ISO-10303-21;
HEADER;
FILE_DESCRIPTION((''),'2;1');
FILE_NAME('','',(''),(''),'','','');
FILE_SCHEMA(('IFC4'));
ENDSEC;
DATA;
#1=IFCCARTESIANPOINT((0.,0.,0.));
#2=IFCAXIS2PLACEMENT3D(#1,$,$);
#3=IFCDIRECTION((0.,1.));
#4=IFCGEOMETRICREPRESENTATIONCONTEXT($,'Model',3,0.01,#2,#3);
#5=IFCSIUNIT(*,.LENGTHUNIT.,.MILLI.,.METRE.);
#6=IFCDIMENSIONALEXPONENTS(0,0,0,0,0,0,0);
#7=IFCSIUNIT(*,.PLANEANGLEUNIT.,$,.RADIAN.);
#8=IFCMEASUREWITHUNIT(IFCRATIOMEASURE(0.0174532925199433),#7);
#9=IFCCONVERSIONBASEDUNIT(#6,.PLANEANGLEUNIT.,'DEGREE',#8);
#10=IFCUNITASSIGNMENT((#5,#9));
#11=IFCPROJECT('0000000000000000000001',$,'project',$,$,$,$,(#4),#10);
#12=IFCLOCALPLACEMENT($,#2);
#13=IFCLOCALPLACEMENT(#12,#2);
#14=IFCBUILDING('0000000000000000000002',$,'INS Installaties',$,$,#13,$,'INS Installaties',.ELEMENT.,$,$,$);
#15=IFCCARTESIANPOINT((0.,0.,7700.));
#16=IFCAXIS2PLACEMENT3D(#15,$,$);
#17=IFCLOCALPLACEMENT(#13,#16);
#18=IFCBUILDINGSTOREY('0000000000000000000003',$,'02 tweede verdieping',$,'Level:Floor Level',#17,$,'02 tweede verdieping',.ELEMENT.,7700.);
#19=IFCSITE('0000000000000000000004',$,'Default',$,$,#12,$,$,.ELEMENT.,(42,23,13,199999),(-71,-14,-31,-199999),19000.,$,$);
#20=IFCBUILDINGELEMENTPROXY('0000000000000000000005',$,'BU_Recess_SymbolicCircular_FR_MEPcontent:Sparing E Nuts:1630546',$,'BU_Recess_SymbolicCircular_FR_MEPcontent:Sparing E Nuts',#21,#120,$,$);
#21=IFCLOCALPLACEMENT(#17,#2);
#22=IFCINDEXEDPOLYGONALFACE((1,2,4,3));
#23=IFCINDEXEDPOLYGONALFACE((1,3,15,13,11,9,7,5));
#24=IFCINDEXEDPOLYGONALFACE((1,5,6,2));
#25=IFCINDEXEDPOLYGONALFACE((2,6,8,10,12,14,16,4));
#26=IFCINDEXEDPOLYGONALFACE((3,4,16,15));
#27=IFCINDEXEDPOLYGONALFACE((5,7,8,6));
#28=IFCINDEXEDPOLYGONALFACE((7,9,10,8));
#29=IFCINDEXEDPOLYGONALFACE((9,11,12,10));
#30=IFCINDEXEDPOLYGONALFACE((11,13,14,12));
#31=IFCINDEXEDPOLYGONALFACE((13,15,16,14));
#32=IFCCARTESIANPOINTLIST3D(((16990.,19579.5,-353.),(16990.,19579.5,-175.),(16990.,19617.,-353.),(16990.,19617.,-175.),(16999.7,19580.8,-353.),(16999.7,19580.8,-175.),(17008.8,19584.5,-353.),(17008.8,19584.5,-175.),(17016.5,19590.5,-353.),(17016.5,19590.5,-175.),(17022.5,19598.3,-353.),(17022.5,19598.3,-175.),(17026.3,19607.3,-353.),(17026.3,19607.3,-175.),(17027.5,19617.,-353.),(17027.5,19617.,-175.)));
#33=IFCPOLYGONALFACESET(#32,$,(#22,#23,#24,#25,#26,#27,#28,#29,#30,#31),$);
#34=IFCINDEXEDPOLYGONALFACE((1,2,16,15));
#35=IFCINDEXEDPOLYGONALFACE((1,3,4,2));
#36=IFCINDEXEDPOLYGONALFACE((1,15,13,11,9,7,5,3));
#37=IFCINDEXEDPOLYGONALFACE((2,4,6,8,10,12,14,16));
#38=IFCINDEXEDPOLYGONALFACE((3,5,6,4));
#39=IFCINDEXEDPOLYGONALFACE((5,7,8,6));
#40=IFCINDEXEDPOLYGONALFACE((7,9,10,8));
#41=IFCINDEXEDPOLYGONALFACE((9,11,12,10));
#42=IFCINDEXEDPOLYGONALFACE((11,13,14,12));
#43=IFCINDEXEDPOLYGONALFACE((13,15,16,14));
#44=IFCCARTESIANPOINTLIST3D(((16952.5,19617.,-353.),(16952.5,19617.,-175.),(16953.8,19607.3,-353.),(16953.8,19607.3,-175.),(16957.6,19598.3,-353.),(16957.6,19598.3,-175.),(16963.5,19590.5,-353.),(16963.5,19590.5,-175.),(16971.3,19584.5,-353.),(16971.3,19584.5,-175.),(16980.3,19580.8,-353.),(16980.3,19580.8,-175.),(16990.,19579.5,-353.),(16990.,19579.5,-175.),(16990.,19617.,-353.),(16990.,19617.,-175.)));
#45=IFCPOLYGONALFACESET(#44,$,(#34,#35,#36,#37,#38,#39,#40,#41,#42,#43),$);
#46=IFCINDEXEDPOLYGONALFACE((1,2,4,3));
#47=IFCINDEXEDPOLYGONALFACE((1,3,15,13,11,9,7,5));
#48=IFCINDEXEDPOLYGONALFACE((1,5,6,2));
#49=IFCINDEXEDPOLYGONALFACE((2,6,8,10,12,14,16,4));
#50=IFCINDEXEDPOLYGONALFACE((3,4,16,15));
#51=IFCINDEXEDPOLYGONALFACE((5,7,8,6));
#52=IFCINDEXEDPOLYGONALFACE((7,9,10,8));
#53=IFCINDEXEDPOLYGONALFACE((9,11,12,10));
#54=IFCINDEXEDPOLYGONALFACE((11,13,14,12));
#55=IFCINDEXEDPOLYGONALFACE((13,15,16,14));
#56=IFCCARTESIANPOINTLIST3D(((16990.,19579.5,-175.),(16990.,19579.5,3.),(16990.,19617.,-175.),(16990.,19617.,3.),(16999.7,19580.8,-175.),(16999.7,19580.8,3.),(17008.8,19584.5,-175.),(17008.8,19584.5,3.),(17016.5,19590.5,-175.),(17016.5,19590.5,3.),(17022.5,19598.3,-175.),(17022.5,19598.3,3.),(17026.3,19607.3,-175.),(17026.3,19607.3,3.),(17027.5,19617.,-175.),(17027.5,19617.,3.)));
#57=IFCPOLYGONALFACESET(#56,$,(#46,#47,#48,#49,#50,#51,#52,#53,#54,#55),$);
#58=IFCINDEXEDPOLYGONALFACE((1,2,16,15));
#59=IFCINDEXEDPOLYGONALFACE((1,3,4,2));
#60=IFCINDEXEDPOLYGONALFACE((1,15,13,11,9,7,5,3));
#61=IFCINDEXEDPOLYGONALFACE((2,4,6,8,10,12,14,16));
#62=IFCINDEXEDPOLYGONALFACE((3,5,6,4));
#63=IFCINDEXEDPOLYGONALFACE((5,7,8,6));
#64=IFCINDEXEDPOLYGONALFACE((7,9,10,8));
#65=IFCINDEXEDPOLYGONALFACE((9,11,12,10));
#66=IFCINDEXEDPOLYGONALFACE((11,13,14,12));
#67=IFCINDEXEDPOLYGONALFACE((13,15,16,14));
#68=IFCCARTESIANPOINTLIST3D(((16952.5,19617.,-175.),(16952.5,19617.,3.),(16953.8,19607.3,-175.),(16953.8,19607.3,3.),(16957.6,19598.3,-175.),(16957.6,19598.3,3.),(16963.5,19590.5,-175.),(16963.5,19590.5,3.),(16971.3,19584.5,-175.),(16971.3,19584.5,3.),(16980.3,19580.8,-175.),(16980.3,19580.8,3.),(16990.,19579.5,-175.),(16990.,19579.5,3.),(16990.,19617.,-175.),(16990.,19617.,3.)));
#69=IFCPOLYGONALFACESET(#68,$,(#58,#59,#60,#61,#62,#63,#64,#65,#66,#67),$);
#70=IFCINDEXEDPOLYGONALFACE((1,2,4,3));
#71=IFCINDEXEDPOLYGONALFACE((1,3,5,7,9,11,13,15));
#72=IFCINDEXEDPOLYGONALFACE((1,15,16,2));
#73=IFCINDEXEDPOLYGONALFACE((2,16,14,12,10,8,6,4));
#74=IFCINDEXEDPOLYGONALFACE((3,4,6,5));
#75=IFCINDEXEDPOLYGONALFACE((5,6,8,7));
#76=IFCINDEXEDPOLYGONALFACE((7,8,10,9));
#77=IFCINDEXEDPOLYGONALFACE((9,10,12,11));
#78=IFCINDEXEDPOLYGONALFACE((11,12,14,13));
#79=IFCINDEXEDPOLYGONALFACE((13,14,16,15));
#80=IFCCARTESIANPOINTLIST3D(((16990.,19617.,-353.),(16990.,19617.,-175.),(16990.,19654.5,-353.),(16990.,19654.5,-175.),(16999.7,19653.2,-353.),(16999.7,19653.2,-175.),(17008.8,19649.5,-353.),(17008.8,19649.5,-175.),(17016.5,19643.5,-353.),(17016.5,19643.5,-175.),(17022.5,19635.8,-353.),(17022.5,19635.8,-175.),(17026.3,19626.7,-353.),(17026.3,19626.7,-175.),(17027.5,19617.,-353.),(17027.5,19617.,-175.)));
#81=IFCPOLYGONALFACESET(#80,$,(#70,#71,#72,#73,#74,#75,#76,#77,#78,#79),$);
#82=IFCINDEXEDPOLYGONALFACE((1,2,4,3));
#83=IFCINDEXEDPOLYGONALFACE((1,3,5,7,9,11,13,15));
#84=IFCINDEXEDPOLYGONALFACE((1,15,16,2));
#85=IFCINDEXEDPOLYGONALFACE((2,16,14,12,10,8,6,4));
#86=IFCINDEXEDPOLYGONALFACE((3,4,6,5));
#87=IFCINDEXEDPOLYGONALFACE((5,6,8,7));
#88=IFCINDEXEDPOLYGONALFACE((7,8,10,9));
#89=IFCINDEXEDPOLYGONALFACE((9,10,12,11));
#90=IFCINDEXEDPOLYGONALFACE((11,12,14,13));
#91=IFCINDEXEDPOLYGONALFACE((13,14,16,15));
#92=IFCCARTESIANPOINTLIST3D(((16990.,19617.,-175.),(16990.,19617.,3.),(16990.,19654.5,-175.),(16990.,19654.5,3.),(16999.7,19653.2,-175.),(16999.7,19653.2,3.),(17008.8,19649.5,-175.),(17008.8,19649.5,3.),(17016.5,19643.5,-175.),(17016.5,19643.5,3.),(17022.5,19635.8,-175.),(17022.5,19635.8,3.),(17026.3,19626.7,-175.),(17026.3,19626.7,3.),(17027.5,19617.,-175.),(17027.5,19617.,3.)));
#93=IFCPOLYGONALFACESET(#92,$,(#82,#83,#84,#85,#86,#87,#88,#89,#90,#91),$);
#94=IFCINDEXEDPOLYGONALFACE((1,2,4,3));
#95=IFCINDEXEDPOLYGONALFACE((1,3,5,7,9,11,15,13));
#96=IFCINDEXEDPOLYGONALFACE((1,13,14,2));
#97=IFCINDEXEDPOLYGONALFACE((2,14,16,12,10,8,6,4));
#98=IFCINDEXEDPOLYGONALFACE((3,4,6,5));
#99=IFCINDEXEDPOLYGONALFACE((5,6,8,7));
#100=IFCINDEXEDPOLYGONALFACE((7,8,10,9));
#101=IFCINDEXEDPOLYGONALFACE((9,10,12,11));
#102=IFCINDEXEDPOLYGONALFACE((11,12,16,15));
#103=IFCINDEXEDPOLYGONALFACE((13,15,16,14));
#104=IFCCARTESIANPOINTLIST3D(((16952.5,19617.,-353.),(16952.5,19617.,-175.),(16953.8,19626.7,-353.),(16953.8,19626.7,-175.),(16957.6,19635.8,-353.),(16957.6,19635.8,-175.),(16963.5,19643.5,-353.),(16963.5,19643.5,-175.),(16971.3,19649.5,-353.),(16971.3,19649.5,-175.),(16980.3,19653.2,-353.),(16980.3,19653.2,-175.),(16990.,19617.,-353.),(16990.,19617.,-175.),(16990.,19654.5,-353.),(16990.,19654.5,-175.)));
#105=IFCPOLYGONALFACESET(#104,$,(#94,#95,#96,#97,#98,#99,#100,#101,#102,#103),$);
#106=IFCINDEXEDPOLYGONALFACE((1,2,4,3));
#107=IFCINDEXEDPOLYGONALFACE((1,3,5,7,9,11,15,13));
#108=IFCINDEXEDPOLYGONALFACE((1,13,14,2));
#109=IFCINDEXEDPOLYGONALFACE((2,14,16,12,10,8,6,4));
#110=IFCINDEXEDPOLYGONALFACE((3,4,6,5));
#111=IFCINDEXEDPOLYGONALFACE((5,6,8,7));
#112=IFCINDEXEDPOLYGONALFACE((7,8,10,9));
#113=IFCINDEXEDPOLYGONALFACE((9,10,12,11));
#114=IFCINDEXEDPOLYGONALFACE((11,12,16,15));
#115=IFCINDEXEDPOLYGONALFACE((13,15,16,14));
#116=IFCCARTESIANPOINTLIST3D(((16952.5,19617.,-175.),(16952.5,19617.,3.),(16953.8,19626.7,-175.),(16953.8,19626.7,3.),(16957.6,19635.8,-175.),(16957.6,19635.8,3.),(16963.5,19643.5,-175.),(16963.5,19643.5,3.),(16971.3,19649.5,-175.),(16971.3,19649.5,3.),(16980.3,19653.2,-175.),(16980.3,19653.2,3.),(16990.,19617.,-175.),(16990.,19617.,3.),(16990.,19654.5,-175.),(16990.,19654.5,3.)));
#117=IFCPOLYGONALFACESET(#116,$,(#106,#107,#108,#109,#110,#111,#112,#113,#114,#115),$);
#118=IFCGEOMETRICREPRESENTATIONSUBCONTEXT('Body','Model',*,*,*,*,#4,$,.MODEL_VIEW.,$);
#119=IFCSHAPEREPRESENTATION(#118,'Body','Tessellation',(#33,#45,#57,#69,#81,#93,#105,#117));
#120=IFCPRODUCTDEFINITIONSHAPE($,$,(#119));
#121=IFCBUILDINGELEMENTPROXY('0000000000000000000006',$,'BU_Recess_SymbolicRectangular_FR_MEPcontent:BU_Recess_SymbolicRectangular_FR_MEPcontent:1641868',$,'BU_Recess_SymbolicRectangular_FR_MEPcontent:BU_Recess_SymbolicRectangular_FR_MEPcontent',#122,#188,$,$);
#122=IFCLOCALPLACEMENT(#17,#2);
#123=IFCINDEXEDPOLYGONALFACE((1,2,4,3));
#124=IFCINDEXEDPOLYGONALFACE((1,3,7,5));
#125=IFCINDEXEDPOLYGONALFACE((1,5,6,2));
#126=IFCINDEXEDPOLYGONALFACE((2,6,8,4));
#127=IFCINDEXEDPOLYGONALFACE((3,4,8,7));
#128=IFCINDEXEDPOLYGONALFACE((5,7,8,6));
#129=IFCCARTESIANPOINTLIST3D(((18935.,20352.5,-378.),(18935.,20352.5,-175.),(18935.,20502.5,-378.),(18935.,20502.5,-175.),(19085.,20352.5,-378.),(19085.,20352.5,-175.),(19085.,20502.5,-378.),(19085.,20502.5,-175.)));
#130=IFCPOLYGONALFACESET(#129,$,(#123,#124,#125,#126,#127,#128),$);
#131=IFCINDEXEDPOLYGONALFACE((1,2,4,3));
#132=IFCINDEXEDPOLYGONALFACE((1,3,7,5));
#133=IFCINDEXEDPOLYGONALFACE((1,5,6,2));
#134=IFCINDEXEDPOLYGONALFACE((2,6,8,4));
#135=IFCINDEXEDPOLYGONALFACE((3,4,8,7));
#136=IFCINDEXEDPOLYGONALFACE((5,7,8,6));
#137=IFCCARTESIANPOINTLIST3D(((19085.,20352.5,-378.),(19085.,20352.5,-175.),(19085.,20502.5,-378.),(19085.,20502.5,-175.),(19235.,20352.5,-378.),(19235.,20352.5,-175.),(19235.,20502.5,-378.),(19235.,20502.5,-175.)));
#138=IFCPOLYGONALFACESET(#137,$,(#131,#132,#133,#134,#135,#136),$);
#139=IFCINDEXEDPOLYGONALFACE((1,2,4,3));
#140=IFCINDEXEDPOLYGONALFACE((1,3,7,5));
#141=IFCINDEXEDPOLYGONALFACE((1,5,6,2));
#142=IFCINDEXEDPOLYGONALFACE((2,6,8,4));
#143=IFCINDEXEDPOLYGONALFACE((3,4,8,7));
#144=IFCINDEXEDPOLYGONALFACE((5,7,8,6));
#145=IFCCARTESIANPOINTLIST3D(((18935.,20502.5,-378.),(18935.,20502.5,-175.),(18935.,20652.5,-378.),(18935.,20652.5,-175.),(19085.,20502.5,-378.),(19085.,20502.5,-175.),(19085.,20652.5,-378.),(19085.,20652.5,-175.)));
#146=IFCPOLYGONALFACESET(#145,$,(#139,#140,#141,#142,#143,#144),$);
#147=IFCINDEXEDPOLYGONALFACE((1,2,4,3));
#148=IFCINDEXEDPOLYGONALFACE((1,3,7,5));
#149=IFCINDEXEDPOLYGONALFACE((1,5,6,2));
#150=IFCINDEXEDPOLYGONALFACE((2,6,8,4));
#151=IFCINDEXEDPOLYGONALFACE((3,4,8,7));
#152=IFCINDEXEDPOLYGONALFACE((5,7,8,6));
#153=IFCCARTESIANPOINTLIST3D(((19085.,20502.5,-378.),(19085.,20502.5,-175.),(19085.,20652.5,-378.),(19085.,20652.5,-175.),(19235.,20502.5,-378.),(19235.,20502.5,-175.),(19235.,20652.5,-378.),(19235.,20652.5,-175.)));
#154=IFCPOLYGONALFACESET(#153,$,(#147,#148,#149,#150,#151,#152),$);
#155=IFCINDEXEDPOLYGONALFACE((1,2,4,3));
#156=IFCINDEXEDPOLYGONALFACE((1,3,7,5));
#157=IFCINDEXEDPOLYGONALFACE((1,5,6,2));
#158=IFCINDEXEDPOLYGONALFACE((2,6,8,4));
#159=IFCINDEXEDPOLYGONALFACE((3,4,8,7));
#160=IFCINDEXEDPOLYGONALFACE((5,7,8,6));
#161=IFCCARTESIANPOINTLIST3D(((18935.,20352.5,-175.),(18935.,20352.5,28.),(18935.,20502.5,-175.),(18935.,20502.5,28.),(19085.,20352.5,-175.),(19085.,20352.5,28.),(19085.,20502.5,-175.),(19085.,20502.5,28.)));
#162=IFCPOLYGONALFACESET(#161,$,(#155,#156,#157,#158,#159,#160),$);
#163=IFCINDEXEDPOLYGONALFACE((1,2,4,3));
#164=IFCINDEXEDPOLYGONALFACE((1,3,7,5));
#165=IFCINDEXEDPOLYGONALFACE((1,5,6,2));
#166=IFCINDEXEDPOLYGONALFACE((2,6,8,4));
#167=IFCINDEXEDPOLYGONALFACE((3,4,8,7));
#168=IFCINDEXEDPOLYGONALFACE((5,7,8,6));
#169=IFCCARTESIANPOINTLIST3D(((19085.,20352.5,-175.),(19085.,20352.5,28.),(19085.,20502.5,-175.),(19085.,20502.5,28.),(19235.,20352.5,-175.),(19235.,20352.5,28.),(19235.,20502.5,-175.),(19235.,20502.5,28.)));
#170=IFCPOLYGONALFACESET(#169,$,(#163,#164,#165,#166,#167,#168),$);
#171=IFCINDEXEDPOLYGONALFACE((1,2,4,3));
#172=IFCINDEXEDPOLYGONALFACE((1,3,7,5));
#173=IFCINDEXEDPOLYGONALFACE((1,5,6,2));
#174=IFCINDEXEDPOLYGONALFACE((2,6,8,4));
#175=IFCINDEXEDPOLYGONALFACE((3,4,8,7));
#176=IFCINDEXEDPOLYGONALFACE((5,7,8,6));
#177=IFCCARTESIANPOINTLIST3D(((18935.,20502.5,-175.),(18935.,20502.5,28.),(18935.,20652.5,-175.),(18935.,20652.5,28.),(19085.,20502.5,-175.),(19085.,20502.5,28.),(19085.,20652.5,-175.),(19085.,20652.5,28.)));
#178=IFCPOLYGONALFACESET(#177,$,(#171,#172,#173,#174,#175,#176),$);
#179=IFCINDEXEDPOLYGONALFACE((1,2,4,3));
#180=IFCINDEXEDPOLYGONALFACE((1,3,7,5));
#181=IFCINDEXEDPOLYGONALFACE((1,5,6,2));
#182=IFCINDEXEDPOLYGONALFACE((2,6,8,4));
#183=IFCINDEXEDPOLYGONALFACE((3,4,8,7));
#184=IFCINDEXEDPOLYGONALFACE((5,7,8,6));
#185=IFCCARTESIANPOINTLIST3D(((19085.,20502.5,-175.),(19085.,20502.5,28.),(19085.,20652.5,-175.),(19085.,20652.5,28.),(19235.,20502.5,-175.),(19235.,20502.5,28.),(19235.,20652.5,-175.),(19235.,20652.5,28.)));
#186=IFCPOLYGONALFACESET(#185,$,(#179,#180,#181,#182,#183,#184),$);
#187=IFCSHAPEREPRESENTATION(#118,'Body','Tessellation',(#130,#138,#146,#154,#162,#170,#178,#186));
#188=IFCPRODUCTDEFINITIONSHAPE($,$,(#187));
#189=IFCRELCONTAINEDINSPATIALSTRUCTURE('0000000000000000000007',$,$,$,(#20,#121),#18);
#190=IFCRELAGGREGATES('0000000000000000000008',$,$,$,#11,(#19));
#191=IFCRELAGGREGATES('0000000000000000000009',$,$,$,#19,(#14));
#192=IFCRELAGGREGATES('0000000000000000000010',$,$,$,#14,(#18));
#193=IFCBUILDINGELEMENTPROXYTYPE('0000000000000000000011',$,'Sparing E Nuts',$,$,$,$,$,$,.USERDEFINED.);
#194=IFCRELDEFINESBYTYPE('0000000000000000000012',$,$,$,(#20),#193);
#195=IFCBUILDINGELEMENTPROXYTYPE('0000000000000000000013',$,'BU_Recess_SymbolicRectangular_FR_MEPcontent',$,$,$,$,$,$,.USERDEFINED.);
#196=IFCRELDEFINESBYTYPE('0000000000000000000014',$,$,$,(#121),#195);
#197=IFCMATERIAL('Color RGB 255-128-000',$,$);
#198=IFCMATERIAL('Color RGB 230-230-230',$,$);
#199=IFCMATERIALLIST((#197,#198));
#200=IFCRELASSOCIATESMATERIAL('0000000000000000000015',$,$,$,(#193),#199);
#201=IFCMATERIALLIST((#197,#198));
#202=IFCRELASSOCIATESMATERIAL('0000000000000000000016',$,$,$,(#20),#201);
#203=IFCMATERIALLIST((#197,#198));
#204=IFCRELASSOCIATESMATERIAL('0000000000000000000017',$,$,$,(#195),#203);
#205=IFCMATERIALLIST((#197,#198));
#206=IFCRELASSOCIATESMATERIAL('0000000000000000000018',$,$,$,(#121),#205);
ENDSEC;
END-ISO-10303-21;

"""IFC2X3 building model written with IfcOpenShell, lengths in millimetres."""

from ifc_helpers import new_model, entity, si_unit, converted_unit, direction, frame, frame_2d, origin, origin_2d_with_axis, place, context, subcontext, project, spatial, polyline, circle_curve, parameter, trimmed, segment, composite_curve, rectangle, outline, extrude, source, transform, mapped, material, material_list, type_object, type_shapes, element, save


model = new_model("IFC2X3")

# Units and contexts
model_context = context("Model", 3, precision=0.01, world=origin(), true_north=direction((0.0, 1.0)))
body_context = subcontext(model_context, "Body", "Model", "MODEL_VIEW")
ifc_project = project(units=[si_unit("LENGTHUNIT", "METRE", prefix="MILLI"), converted_unit("PLANEANGLEUNIT", "DEGREE", entity("IfcRatioMeasure", 0.0174532925199433), si_unit("PLANEANGLEUNIT", "RADIAN"), dimensions=[0, 0, 0, 0, 0, 0, 0])], contexts=[model_context])

# Site, building, storey
site_placement = place(None, origin())
site = spatial("IfcSite", under=ifc_project, at=site_placement, Name="Default", CompositionType="ELEMENT", RefLatitude=(42, 23, 13, 199999), RefLongitude=(-71, -14, -31, -199999), RefElevation=19000.0)
building_placement = place(site_placement, origin())
building = spatial("IfcBuilding", under=site, at=building_placement, Name="INS Installaties", LongName="INS Installaties", CompositionType="ELEMENT")
storey_placement = place(building_placement, frame((0.0, 0.0, 7700.0)))
storey = spatial("IfcBuildingStorey", under=building, at=storey_placement, Name="02 tweede verdieping", ObjectType="Level:Floor Level", LongName="02 tweede verdieping", CompositionType="ELEMENT", Elevation=7700.0)

# Building element proxies
ifc_material_1 = material(Name="Color RGB 255-128-000")
ifc_material_2 = material(Name="Color RGB 230-230-230")
ifc_material_list_1 = material_list([ifc_material_1, ifc_material_2])
building_element_proxy_type_1 = type_object("IfcBuildingElementProxyType", Name="Sparing E Nuts", PredefinedType="USERDEFINED", material=ifc_material_list_1)
shared_shape_1 = source(origin(), body_context, "Body", "SweptSolid", [
    extrude(outline(composite_curve([segment(polyline([(-25.0, -12.5), (12.5, -12.5)]), True, "CONTINUOUS"), segment(polyline([(12.5, -12.5), (12.5, 25.0)]), True, "CONTINUOUS"), segment(trimmed(circle_curve(frame_2d((12.5, -12.5), x_axis=(1.0, 0.0)), 37.5), [parameter(90.0)], [parameter(180.0)], True, "PARAMETER"), True, "CONTINUOUS")], self_intersect=False)), frame((12.5, -12.5, -353.0), z_axis=(0.0, 0.0, 1.0), x_axis=(-1.0, 0.0, 0.0)), (0.0, 0.0, 1.0), 178.0),
    extrude(outline(composite_curve([segment(trimmed(circle_curve(frame_2d((12.5, 12.5), x_axis=(1.0, 0.0)), 37.5), [parameter(180.0)], [parameter(270.0)], True, "PARAMETER"), True, "CONTINUOUS"), segment(polyline([(12.5, -25.0), (12.5, 12.5)]), True, "CONTINUOUS"), segment(polyline([(12.5, 12.5), (-25.0, 12.5)]), True, "CONTINUOUS")], self_intersect=False)), frame((-12.5, -12.5, -353.0)), (0.0, 0.0, 1.0), 178.0),
    extrude(outline(composite_curve([segment(polyline([(-25.0, -12.5), (12.5, -12.5)]), True, "CONTINUOUS"), segment(polyline([(12.5, -12.5), (12.5, 25.0)]), True, "CONTINUOUS"), segment(trimmed(circle_curve(frame_2d((12.5, -12.5), x_axis=(1.0, 0.0)), 37.5), [parameter(90.0)], [parameter(180.0)], True, "PARAMETER"), True, "CONTINUOUS")], self_intersect=False)), frame((12.5, -12.5, -175.0), z_axis=(0.0, 0.0, 1.0), x_axis=(-1.0, 0.0, 0.0)), (0.0, 0.0, 1.0), 178.0),
    extrude(outline(composite_curve([segment(trimmed(circle_curve(frame_2d((12.5, 12.5), x_axis=(1.0, 0.0)), 37.5), [parameter(180.0)], [parameter(270.0)], True, "PARAMETER"), True, "CONTINUOUS"), segment(polyline([(12.5, -25.0), (12.5, 12.5)]), True, "CONTINUOUS"), segment(polyline([(12.5, 12.5), (-25.0, 12.5)]), True, "CONTINUOUS")], self_intersect=False)), frame((-12.5, -12.5, -175.0)), (0.0, 0.0, 1.0), 178.0),
    extrude(outline(composite_curve([segment(trimmed(circle_curve(frame_2d((12.5, 12.5), x_axis=(1.0, 0.0)), 37.5), [parameter(180.0)], [parameter(270.0)], True, "PARAMETER"), True, "CONTINUOUS"), segment(polyline([(12.5, -25.0), (12.5, 12.5)]), True, "CONTINUOUS"), segment(polyline([(12.5, 12.5), (-25.0, 12.5)]), True, "CONTINUOUS")], self_intersect=False)), frame((12.5, 12.5, -353.0), z_axis=(0.0, 0.0, 1.0), x_axis=(-1.0, 0.0, 0.0)), (0.0, 0.0, 1.0), 178.0),
    extrude(outline(composite_curve([segment(trimmed(circle_curve(frame_2d((12.5, 12.5), x_axis=(1.0, 0.0)), 37.5), [parameter(180.0)], [parameter(270.0)], True, "PARAMETER"), True, "CONTINUOUS"), segment(polyline([(12.5, -25.0), (12.5, 12.5)]), True, "CONTINUOUS"), segment(polyline([(12.5, 12.5), (-25.0, 12.5)]), True, "CONTINUOUS")], self_intersect=False)), frame((12.5, 12.5, -175.0), z_axis=(0.0, 0.0, 1.0), x_axis=(-1.0, 0.0, 0.0)), (0.0, 0.0, 1.0), 178.0),
    extrude(outline(composite_curve([segment(polyline([(-25.0, -12.5), (12.5, -12.5)]), True, "CONTINUOUS"), segment(polyline([(12.5, -12.5), (12.5, 25.0)]), True, "CONTINUOUS"), segment(trimmed(circle_curve(frame_2d((12.5, -12.5), x_axis=(1.0, 0.0)), 37.5), [parameter(90.0)], [parameter(180.0)], True, "PARAMETER"), True, "CONTINUOUS")], self_intersect=False)), frame((-12.5, 12.5, -353.0)), (0.0, 0.0, 1.0), 178.0),
    extrude(outline(composite_curve([segment(polyline([(-25.0, -12.5), (12.5, -12.5)]), True, "CONTINUOUS"), segment(polyline([(12.5, -12.5), (12.5, 25.0)]), True, "CONTINUOUS"), segment(trimmed(circle_curve(frame_2d((12.5, -12.5), x_axis=(1.0, 0.0)), 37.5), [parameter(90.0)], [parameter(180.0)], True, "PARAMETER"), True, "CONTINUOUS")], self_intersect=False)), frame((-12.5, 12.5, -175.0)), (0.0, 0.0, 1.0), 178.0),
])
type_shapes(building_element_proxy_type_1, [shared_shape_1])
ifc_material_list_2 = material_list([ifc_material_1, ifc_material_2])
proxy_1_placement = place(storey_placement, frame((16990.0, 19617.0, 0.0)))
element("IfcBuildingElementProxy", 1, at=proxy_1_placement, inside=storey, type_object=building_element_proxy_type_1, material=ifc_material_list_2, Name="BU_Recess_SymbolicCircular_FR_MEPcontent:Sparing E Nuts:1630546", ObjectType="BU_Recess_SymbolicCircular_FR_MEPcontent:Sparing E Nuts", context=body_context, shape_type="MappedRepresentation", body=[
    mapped(shared_shape_1, transform((0.0, 0.0, 0.0), scale=1.0)),
])
ifc_material_list_3 = material_list([ifc_material_1, ifc_material_2])
ifc_material_list_4 = material_list([ifc_material_1, ifc_material_2])
building_element_proxy_type_2 = type_object("IfcBuildingElementProxyType", Name="BU_Recess_SymbolicRectangular_FR_MEPcontent", PredefinedType="USERDEFINED", material=ifc_material_list_4)
shared_shape_2 = source(origin(), body_context, "Body", "SweptSolid", [
    extrude(rectangle(XDim=150.0, YDim=150.0, at=origin_2d_with_axis()), frame((75.0, 75.0, -403.0), z_axis=(0.0, 0.0, 1.0), x_axis=(0.0, -1.0, 0.0)), (0.0, 0.0, 1.0), 203.0),
    extrude(rectangle(XDim=150.0, YDim=150.0, at=frame_2d((0.0, 0.0), x_axis=(1.0, 0.0))), frame((-75.0, 75.0, -403.0), z_axis=(0.0, 0.0, 1.0), x_axis=(-1.0, 0.0, 0.0)), (0.0, 0.0, 1.0), 203.0),
    extrude(rectangle(XDim=150.0, YDim=150.0, at=frame_2d((0.0, 0.0), x_axis=(1.0, 0.0))), frame((75.0, -75.0, -403.0)), (0.0, 0.0, 1.0), 203.0),
    extrude(rectangle(XDim=150.0, YDim=150.0, at=origin_2d_with_axis()), frame((-75.0, -75.0, -403.0), z_axis=(0.0, 0.0, 1.0), x_axis=(0.0, 1.0, 0.0)), (0.0, 0.0, 1.0), 203.0),
    extrude(rectangle(XDim=150.0, YDim=150.0, at=origin_2d_with_axis()), frame((75.0, 75.0, -200.0), z_axis=(0.0, 0.0, 1.0), x_axis=(0.0, -1.0, 0.0)), (0.0, 0.0, 1.0), 203.0),
    extrude(rectangle(XDim=150.0, YDim=150.0, at=frame_2d((0.0, 0.0), x_axis=(1.0, 0.0))), frame((-75.0, 75.0, -200.0), z_axis=(0.0, 0.0, 1.0), x_axis=(-1.0, 0.0, 0.0)), (0.0, 0.0, 1.0), 203.0),
    extrude(rectangle(XDim=150.0, YDim=150.0, at=frame_2d((0.0, 0.0), x_axis=(1.0, 0.0))), frame((75.0, -75.0, -200.0)), (0.0, 0.0, 1.0), 203.0),
    extrude(rectangle(XDim=150.0, YDim=150.0, at=origin_2d_with_axis()), frame((-75.0, -75.0, -200.0), z_axis=(0.0, 0.0, 1.0), x_axis=(0.0, 1.0, 0.0)), (0.0, 0.0, 1.0), 203.0),
])
type_shapes(building_element_proxy_type_2, [shared_shape_2])
proxy_2_placement = place(storey_placement, frame((19085.0, 20502.5, 25.0), z_axis=(0.0, 0.0, 1.0), x_axis=(-1.0, 0.0, 0.0)))
element("IfcBuildingElementProxy", 2, at=proxy_2_placement, inside=storey, type_object=building_element_proxy_type_2, material=ifc_material_list_3, Name="BU_Recess_SymbolicRectangular_FR_MEPcontent:BU_Recess_SymbolicRectangular_FR_MEPcontent:1641868", ObjectType="BU_Recess_SymbolicRectangular_FR_MEPcontent:BU_Recess_SymbolicRectangular_FR_MEPcontent", context=body_context, shape_type="MappedRepresentation", body=[
    mapped(shared_shape_2, transform((0.0, 0.0, 0.0), scale=1.0)),
])

save(model, "model.ifc")
